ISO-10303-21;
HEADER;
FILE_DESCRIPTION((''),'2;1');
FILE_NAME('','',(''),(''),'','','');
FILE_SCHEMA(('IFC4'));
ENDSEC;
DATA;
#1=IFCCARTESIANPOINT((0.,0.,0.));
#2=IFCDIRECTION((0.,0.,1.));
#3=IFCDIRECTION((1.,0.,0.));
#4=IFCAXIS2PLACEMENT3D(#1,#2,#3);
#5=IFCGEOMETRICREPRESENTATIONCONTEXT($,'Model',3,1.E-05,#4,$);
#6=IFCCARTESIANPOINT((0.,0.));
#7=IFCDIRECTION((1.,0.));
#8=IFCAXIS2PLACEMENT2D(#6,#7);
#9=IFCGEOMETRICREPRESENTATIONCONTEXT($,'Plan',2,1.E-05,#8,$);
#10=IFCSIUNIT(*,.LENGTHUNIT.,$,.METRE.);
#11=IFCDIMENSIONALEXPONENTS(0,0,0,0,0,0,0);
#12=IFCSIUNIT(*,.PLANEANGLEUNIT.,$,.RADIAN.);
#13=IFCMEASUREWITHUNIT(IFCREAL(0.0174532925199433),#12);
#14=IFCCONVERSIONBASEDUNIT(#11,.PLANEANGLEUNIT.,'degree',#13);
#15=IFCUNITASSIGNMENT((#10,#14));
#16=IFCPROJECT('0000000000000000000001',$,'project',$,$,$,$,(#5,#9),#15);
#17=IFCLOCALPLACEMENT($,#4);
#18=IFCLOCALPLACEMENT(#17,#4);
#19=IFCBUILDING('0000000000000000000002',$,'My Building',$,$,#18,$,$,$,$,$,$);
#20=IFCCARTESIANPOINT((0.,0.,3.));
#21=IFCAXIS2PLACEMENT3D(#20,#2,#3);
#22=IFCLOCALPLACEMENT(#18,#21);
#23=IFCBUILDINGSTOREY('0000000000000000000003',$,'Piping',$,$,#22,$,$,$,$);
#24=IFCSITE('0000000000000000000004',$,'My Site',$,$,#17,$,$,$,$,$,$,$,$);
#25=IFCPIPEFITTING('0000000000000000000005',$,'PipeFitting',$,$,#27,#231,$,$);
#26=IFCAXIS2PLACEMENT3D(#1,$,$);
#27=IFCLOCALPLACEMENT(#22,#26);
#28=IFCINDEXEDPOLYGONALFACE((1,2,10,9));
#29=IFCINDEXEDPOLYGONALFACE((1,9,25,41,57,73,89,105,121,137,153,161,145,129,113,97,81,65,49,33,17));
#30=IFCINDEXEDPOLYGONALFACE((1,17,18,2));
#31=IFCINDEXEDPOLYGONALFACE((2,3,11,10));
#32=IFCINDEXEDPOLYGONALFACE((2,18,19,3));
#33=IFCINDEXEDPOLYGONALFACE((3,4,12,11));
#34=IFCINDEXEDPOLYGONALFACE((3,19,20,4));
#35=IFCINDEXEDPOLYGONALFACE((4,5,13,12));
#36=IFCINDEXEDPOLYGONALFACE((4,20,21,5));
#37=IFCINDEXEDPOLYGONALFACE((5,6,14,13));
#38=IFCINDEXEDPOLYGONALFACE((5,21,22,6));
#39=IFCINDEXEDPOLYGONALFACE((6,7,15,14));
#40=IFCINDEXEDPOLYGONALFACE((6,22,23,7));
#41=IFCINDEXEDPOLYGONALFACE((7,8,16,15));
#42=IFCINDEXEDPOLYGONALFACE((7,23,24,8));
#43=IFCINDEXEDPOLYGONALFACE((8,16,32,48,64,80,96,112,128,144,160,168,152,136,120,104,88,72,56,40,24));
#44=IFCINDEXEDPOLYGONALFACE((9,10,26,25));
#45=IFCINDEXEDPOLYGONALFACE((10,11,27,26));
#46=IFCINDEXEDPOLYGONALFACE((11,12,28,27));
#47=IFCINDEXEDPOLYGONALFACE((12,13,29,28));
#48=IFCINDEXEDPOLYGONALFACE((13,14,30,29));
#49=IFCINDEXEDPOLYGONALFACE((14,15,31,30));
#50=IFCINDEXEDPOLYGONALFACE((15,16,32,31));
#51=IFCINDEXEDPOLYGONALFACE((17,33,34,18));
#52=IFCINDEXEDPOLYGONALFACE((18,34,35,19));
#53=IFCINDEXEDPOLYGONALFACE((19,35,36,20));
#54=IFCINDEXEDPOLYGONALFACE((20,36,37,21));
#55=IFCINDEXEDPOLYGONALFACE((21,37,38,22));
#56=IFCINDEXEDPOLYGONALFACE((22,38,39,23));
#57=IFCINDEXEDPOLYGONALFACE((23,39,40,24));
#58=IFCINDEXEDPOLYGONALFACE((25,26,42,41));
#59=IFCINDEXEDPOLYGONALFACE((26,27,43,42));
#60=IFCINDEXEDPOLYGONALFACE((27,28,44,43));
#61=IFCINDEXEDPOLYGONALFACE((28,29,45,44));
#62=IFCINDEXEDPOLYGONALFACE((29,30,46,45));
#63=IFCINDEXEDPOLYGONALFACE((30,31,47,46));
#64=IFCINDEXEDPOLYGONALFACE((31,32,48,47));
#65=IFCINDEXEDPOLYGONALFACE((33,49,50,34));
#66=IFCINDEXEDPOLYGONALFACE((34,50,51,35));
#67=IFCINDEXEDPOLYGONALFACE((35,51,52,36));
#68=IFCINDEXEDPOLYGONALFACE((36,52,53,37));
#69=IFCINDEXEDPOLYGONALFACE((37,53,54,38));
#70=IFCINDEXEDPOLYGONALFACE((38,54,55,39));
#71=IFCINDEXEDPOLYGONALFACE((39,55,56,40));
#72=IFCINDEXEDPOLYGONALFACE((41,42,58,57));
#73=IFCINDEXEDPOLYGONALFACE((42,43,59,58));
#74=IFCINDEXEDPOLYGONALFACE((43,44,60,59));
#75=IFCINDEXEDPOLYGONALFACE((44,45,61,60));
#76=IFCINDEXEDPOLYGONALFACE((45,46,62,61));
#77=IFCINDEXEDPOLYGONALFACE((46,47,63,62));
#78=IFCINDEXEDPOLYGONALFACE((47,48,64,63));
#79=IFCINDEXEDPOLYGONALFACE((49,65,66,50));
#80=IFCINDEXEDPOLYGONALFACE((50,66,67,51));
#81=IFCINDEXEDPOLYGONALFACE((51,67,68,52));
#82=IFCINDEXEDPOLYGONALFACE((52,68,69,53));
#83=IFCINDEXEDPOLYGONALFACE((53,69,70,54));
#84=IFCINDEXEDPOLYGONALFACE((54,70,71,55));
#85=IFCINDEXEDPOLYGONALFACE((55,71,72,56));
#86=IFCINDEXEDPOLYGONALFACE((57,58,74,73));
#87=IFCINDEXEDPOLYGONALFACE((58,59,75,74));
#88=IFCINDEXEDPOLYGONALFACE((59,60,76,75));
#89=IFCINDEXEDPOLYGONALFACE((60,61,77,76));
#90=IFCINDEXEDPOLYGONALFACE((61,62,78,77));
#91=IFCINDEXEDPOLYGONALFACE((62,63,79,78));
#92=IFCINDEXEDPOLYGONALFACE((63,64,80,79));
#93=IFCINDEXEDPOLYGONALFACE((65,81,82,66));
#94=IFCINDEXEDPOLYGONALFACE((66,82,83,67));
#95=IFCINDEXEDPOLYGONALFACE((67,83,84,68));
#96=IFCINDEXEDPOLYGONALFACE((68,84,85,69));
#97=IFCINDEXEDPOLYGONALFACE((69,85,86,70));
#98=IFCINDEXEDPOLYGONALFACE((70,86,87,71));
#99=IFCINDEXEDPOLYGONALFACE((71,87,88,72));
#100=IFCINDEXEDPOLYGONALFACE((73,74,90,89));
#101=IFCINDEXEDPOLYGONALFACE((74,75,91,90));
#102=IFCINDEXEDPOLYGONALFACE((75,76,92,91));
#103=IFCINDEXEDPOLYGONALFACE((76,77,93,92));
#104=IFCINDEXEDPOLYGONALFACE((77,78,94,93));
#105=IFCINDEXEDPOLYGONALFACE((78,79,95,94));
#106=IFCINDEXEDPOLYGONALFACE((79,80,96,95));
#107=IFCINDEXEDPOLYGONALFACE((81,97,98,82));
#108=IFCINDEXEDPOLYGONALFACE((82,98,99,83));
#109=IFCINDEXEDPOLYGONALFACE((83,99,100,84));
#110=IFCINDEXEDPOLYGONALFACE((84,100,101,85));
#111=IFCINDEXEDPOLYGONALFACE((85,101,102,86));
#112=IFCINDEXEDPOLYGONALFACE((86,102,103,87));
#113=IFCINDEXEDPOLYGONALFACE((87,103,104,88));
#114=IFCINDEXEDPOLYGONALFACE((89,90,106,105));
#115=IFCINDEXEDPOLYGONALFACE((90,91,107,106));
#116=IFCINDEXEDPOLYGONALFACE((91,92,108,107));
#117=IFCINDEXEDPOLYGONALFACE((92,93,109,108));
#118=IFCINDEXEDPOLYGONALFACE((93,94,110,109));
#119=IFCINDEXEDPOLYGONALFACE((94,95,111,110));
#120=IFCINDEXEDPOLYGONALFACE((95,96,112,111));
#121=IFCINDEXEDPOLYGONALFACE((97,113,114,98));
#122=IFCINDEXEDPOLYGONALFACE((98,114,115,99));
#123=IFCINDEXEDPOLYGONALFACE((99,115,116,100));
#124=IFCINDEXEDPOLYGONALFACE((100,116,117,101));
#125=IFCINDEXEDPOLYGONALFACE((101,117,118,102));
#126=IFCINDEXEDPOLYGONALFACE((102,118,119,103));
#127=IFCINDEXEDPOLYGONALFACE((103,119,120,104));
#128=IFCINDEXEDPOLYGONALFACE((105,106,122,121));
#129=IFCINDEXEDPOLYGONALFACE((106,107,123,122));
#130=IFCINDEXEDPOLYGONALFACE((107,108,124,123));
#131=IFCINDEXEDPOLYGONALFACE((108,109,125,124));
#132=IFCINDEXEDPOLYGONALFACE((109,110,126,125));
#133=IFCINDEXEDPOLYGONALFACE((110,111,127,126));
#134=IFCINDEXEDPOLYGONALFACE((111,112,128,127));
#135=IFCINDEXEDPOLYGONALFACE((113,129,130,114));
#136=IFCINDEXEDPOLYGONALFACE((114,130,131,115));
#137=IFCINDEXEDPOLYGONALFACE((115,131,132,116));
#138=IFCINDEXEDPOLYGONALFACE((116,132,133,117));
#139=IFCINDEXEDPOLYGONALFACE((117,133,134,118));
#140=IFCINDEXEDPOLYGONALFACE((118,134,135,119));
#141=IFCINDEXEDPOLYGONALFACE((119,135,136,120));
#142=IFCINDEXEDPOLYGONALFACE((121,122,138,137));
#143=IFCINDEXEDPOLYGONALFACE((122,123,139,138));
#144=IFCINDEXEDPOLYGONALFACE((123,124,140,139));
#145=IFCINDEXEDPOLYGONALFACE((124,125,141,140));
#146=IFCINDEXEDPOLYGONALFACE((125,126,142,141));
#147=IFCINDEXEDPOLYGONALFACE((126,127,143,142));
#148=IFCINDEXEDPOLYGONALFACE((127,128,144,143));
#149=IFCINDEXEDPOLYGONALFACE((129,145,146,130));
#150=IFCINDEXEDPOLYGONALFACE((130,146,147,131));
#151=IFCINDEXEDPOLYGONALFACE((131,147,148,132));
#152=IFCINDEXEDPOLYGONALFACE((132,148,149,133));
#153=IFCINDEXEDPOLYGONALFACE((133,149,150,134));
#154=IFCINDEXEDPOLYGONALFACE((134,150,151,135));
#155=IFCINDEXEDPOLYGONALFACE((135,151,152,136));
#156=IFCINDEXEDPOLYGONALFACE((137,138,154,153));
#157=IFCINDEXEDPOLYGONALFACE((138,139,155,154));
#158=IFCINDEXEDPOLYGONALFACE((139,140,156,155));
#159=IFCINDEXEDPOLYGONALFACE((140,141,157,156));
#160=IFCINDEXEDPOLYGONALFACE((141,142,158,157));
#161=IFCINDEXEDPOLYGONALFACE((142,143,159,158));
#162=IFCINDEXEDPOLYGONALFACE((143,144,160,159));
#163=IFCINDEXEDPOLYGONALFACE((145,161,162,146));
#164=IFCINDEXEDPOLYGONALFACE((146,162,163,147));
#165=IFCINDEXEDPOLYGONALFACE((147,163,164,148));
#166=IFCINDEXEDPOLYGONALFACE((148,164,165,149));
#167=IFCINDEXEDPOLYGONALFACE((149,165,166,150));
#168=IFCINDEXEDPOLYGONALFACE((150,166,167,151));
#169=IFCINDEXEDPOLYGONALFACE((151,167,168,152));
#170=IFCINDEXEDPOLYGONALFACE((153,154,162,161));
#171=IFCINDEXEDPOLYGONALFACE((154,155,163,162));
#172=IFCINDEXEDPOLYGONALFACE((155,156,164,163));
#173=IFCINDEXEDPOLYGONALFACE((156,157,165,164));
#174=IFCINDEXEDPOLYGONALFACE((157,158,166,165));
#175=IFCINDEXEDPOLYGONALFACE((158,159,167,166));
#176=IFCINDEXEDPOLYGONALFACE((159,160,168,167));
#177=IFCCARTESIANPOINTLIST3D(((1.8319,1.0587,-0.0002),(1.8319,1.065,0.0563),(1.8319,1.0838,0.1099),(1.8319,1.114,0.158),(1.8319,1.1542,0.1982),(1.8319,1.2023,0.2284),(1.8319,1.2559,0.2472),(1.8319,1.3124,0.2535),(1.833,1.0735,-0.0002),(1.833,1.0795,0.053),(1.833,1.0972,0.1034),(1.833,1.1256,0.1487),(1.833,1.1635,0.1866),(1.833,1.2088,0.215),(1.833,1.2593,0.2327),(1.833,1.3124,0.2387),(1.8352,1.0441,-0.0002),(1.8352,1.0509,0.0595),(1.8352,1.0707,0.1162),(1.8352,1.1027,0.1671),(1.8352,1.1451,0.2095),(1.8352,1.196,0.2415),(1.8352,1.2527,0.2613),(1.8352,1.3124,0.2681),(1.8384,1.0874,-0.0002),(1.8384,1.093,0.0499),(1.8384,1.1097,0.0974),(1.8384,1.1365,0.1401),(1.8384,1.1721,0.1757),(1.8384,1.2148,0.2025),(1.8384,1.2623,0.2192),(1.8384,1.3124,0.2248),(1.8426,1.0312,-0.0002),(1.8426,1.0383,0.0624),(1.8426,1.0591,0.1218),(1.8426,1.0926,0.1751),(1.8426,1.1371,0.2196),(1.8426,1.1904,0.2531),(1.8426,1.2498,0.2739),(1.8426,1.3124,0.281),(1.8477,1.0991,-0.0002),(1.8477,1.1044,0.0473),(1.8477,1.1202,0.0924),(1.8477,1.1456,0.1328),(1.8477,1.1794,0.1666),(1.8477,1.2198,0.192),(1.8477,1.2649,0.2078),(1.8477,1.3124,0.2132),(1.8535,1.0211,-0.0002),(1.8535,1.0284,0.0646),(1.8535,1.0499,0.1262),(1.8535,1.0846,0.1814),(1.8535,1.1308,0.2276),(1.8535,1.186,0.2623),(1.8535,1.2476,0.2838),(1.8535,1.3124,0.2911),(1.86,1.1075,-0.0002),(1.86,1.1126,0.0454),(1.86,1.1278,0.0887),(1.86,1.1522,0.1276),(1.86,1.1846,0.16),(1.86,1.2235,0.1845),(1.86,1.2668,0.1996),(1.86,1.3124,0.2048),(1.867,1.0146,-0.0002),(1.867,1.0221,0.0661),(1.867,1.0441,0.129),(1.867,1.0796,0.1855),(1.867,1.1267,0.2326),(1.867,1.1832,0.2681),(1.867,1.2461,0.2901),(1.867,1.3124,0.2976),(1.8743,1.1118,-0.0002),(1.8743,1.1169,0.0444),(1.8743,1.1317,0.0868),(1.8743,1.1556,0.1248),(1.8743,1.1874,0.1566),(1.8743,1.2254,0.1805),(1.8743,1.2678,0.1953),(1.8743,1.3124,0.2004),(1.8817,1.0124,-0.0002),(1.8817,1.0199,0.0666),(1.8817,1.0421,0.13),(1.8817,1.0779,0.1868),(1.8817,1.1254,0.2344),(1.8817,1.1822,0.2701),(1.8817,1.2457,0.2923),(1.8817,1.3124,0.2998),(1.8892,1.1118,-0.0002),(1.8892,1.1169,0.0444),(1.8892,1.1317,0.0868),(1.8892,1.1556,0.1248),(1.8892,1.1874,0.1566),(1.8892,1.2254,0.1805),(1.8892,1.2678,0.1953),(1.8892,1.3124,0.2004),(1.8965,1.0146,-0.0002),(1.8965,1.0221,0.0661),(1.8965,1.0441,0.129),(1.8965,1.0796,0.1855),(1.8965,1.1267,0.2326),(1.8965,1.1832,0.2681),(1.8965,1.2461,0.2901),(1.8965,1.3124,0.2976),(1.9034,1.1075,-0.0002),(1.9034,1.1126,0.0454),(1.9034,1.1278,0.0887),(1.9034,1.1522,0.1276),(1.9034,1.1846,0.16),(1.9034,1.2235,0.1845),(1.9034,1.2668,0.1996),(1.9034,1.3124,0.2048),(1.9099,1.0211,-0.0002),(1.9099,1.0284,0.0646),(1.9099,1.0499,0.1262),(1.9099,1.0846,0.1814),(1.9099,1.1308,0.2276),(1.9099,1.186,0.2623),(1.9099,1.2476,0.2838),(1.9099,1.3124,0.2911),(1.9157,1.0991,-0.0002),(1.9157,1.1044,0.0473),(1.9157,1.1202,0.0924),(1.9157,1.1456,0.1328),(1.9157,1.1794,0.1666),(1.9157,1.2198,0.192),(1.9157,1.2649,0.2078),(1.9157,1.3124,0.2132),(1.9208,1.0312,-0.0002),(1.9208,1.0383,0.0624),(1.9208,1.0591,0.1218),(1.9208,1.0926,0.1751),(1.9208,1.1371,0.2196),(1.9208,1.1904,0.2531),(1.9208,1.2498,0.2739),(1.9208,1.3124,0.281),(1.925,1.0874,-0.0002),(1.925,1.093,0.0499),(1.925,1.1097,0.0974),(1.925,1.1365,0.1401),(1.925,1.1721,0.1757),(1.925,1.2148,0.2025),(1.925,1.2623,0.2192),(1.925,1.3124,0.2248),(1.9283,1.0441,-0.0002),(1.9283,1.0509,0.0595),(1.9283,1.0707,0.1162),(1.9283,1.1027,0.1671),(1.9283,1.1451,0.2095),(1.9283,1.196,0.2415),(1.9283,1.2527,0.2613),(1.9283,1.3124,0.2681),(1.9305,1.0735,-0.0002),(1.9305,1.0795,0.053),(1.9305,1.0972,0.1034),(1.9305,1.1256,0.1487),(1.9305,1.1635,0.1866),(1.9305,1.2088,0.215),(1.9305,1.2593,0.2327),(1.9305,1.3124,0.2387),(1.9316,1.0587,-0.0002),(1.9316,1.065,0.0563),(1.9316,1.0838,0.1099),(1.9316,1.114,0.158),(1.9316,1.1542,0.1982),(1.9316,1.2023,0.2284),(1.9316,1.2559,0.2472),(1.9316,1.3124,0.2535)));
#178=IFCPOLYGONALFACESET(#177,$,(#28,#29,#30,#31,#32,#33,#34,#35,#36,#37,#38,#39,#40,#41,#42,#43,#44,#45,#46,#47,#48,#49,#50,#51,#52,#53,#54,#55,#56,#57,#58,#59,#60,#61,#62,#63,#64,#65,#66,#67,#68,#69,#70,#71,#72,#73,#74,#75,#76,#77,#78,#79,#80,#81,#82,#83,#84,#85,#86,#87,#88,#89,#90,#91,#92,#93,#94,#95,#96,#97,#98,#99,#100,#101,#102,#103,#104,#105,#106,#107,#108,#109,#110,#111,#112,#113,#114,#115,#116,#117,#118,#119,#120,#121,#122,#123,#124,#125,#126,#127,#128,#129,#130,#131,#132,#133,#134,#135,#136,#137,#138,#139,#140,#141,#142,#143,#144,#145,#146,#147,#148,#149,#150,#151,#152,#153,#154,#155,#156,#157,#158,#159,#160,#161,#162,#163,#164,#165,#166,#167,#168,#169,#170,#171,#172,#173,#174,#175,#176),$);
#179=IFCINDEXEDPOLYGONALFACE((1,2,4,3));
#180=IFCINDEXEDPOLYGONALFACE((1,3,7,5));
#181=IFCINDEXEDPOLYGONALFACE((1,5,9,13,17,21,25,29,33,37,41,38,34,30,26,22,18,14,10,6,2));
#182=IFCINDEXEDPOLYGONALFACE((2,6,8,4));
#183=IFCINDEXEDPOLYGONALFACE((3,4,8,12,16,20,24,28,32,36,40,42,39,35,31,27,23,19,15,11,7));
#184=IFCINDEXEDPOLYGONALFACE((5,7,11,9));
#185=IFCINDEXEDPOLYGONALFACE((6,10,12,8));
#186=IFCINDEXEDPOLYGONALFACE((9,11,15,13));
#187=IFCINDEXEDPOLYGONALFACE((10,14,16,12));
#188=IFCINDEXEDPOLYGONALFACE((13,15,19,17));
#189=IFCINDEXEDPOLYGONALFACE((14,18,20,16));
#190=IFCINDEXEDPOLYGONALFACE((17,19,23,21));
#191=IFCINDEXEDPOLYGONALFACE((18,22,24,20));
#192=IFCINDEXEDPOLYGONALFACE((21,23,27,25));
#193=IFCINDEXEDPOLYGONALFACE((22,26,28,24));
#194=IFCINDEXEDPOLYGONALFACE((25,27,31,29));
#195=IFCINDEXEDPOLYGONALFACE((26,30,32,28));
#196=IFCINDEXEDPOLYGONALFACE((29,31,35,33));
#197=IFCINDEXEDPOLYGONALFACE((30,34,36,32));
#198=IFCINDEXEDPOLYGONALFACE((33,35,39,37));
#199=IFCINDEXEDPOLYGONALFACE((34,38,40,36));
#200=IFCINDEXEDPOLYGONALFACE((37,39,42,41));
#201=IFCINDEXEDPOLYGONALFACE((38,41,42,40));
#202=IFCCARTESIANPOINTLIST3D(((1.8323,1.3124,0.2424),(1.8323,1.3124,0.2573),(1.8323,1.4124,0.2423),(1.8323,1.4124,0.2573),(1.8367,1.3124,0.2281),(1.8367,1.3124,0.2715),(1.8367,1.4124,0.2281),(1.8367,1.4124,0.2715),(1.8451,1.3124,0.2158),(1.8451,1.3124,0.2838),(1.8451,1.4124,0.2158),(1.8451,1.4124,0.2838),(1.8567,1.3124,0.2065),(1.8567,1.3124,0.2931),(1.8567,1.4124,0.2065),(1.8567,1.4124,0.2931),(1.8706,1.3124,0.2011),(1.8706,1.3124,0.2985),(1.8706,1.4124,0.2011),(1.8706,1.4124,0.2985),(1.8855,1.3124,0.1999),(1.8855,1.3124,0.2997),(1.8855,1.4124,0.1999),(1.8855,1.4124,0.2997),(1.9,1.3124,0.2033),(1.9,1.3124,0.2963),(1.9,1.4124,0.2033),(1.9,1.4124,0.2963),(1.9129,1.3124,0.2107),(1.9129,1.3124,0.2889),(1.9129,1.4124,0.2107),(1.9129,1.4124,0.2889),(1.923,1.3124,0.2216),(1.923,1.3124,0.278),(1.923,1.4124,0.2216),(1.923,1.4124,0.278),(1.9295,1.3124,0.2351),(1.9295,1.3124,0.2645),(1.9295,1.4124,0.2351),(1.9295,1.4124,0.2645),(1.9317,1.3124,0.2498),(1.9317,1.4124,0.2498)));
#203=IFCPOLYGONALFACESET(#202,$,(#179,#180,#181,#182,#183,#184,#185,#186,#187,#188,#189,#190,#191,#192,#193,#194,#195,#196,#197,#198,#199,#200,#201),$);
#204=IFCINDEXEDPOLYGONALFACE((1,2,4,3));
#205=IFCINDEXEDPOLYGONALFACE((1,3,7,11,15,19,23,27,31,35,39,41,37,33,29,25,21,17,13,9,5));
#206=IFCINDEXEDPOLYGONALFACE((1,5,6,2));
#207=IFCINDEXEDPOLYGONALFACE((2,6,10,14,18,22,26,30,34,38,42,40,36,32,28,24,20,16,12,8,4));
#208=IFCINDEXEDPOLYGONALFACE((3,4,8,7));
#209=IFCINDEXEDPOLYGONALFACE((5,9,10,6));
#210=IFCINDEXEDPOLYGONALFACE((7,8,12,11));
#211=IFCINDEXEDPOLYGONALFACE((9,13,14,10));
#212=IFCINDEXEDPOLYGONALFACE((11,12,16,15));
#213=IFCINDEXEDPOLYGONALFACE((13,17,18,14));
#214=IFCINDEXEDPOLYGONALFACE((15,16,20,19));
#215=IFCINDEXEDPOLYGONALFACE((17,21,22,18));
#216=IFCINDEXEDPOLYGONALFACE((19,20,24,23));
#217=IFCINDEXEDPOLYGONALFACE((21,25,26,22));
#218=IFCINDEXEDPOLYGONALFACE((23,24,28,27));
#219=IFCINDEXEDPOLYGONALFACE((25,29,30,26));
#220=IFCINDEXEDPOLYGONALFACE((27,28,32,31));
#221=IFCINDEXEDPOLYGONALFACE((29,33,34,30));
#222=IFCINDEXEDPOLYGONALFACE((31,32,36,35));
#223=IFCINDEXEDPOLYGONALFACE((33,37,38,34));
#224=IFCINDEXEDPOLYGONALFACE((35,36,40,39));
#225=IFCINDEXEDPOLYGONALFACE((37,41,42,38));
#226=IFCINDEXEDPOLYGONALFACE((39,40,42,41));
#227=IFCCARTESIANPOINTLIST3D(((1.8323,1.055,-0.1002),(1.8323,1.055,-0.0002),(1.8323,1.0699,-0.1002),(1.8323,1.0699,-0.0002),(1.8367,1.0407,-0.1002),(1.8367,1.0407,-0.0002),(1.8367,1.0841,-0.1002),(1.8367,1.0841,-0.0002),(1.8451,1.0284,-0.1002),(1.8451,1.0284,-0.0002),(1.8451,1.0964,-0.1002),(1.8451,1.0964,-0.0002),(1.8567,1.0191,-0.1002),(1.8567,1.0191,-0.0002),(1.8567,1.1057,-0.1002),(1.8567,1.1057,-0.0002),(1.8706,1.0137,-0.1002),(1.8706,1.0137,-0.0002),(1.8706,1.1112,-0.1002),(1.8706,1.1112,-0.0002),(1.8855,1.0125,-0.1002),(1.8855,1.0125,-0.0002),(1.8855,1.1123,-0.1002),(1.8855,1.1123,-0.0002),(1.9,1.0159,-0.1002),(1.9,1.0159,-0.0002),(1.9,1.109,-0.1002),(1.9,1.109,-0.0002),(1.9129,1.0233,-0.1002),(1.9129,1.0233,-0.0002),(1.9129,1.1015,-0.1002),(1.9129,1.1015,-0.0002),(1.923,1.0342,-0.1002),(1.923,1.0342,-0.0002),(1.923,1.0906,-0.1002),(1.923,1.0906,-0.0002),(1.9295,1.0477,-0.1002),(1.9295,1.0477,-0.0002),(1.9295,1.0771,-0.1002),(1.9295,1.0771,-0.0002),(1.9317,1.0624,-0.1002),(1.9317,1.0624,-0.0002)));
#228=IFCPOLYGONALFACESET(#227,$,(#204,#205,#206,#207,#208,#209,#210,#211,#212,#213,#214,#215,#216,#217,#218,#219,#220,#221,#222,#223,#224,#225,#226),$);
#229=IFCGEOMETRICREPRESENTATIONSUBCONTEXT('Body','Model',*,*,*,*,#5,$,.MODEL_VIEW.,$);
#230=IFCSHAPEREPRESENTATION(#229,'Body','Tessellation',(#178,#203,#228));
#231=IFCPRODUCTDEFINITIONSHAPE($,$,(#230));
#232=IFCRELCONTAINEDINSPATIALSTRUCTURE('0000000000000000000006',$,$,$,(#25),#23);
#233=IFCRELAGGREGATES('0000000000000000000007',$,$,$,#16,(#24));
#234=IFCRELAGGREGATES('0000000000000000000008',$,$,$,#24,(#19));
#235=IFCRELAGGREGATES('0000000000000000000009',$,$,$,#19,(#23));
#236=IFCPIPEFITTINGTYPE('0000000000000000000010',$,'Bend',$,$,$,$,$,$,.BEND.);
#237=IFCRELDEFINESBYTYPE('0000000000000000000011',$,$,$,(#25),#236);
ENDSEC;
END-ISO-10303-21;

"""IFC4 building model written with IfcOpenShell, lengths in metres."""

from ifc_helpers import new_model, entity, si_unit, converted_unit, frame, origin_with_axes, origin_2d_with_axis, place, context, subcontext, project, spatial, circle, extrude, source, transform, mapped, type_object, type_shapes, element, save


model = new_model("IFC4")

# Units and contexts
model_context = context("Model", 3, precision=1e-05, world=origin_with_axes())
plan_context = context("Plan", 2, precision=1e-05, world=origin_2d_with_axis())
body_context = subcontext(model_context, "Body", "Model", "MODEL_VIEW")
ifc_project = project(units=[si_unit("LENGTHUNIT", "METRE"), converted_unit("PLANEANGLEUNIT", "degree", entity("IfcReal", 0.0174532925199433), si_unit("PLANEANGLEUNIT", "RADIAN"), dimensions=[0, 0, 0, 0, 0, 0, 0])], contexts=[model_context, plan_context])

# Site, building, storey
site_placement = place(None, origin_with_axes())
site = spatial("IfcSite", under=ifc_project, at=site_placement, Name="My Site")
building_placement = place(site_placement, origin_with_axes())
building = spatial("IfcBuilding", under=site, at=building_placement, Name="My Building")
storey_placement = place(building_placement, frame((0.0, 0.0, 3.0), z_axis=(0.0, 0.0, 1.0), x_axis=(1.0, 0.0, 0.0)))
storey = spatial("IfcBuildingStorey", under=building, at=storey_placement, Name="Piping")

# Pipe fitting
pipe_fitting_type_1 = type_object("IfcPipeFittingType", Name="Bend", PredefinedType="BEND")
shared_shape = source(origin_with_axes(), body_context, "Body", "SolidModel", [
    entity("IfcSweptDiskSolid", entity("IfcIndexedPolyCurve", entity("IfcCartesianPointList3D", [[0.0, 0.0, 0.1], [0.0, -0.0732, 0.2768], [0.0, -0.25, 0.35]]), [entity("IfcArcIndex", [1, 2, 3])]), 0.05),
    extrude(circle(Radius=0.05), origin_with_axes(), (0.0, 0.0, 1.0), 0.1),
    extrude(circle(Radius=0.05), frame((0.0, -0.25, 0.35), z_axis=(0.0, -1.0, -0.00003), x_axis=(1.0, 0.0, 0.0)), (0.0, 0.0, 1.0), 0.1),
])
type_shapes(pipe_fitting_type_1, [shared_shape])
for number, where, z_axis, x_axis, name in (
    (1, (1.8817, 1.4124, 0.2498), (0.0, -1.0, 0.000008), (1.0, 0.0, 0.0), "PipeFitting"),
):
    element("IfcPipeFitting", number, at=place(storey_placement, frame(where, z_axis=z_axis, x_axis=x_axis)), inside=storey, type_object=pipe_fitting_type_1, Name=name, context=body_context, shape_type="MappedRepresentation", body=[
        mapped(shared_shape, transform((0.0, 0.0, 0.0), x_axis=(1.0, 0.0, 0.0), y_axis=(0.0, 1.0, 0.0), z_axis=(0.0, 0.0, 1.0), scale=1.0)),
    ])

save(model, "model.ifc")
